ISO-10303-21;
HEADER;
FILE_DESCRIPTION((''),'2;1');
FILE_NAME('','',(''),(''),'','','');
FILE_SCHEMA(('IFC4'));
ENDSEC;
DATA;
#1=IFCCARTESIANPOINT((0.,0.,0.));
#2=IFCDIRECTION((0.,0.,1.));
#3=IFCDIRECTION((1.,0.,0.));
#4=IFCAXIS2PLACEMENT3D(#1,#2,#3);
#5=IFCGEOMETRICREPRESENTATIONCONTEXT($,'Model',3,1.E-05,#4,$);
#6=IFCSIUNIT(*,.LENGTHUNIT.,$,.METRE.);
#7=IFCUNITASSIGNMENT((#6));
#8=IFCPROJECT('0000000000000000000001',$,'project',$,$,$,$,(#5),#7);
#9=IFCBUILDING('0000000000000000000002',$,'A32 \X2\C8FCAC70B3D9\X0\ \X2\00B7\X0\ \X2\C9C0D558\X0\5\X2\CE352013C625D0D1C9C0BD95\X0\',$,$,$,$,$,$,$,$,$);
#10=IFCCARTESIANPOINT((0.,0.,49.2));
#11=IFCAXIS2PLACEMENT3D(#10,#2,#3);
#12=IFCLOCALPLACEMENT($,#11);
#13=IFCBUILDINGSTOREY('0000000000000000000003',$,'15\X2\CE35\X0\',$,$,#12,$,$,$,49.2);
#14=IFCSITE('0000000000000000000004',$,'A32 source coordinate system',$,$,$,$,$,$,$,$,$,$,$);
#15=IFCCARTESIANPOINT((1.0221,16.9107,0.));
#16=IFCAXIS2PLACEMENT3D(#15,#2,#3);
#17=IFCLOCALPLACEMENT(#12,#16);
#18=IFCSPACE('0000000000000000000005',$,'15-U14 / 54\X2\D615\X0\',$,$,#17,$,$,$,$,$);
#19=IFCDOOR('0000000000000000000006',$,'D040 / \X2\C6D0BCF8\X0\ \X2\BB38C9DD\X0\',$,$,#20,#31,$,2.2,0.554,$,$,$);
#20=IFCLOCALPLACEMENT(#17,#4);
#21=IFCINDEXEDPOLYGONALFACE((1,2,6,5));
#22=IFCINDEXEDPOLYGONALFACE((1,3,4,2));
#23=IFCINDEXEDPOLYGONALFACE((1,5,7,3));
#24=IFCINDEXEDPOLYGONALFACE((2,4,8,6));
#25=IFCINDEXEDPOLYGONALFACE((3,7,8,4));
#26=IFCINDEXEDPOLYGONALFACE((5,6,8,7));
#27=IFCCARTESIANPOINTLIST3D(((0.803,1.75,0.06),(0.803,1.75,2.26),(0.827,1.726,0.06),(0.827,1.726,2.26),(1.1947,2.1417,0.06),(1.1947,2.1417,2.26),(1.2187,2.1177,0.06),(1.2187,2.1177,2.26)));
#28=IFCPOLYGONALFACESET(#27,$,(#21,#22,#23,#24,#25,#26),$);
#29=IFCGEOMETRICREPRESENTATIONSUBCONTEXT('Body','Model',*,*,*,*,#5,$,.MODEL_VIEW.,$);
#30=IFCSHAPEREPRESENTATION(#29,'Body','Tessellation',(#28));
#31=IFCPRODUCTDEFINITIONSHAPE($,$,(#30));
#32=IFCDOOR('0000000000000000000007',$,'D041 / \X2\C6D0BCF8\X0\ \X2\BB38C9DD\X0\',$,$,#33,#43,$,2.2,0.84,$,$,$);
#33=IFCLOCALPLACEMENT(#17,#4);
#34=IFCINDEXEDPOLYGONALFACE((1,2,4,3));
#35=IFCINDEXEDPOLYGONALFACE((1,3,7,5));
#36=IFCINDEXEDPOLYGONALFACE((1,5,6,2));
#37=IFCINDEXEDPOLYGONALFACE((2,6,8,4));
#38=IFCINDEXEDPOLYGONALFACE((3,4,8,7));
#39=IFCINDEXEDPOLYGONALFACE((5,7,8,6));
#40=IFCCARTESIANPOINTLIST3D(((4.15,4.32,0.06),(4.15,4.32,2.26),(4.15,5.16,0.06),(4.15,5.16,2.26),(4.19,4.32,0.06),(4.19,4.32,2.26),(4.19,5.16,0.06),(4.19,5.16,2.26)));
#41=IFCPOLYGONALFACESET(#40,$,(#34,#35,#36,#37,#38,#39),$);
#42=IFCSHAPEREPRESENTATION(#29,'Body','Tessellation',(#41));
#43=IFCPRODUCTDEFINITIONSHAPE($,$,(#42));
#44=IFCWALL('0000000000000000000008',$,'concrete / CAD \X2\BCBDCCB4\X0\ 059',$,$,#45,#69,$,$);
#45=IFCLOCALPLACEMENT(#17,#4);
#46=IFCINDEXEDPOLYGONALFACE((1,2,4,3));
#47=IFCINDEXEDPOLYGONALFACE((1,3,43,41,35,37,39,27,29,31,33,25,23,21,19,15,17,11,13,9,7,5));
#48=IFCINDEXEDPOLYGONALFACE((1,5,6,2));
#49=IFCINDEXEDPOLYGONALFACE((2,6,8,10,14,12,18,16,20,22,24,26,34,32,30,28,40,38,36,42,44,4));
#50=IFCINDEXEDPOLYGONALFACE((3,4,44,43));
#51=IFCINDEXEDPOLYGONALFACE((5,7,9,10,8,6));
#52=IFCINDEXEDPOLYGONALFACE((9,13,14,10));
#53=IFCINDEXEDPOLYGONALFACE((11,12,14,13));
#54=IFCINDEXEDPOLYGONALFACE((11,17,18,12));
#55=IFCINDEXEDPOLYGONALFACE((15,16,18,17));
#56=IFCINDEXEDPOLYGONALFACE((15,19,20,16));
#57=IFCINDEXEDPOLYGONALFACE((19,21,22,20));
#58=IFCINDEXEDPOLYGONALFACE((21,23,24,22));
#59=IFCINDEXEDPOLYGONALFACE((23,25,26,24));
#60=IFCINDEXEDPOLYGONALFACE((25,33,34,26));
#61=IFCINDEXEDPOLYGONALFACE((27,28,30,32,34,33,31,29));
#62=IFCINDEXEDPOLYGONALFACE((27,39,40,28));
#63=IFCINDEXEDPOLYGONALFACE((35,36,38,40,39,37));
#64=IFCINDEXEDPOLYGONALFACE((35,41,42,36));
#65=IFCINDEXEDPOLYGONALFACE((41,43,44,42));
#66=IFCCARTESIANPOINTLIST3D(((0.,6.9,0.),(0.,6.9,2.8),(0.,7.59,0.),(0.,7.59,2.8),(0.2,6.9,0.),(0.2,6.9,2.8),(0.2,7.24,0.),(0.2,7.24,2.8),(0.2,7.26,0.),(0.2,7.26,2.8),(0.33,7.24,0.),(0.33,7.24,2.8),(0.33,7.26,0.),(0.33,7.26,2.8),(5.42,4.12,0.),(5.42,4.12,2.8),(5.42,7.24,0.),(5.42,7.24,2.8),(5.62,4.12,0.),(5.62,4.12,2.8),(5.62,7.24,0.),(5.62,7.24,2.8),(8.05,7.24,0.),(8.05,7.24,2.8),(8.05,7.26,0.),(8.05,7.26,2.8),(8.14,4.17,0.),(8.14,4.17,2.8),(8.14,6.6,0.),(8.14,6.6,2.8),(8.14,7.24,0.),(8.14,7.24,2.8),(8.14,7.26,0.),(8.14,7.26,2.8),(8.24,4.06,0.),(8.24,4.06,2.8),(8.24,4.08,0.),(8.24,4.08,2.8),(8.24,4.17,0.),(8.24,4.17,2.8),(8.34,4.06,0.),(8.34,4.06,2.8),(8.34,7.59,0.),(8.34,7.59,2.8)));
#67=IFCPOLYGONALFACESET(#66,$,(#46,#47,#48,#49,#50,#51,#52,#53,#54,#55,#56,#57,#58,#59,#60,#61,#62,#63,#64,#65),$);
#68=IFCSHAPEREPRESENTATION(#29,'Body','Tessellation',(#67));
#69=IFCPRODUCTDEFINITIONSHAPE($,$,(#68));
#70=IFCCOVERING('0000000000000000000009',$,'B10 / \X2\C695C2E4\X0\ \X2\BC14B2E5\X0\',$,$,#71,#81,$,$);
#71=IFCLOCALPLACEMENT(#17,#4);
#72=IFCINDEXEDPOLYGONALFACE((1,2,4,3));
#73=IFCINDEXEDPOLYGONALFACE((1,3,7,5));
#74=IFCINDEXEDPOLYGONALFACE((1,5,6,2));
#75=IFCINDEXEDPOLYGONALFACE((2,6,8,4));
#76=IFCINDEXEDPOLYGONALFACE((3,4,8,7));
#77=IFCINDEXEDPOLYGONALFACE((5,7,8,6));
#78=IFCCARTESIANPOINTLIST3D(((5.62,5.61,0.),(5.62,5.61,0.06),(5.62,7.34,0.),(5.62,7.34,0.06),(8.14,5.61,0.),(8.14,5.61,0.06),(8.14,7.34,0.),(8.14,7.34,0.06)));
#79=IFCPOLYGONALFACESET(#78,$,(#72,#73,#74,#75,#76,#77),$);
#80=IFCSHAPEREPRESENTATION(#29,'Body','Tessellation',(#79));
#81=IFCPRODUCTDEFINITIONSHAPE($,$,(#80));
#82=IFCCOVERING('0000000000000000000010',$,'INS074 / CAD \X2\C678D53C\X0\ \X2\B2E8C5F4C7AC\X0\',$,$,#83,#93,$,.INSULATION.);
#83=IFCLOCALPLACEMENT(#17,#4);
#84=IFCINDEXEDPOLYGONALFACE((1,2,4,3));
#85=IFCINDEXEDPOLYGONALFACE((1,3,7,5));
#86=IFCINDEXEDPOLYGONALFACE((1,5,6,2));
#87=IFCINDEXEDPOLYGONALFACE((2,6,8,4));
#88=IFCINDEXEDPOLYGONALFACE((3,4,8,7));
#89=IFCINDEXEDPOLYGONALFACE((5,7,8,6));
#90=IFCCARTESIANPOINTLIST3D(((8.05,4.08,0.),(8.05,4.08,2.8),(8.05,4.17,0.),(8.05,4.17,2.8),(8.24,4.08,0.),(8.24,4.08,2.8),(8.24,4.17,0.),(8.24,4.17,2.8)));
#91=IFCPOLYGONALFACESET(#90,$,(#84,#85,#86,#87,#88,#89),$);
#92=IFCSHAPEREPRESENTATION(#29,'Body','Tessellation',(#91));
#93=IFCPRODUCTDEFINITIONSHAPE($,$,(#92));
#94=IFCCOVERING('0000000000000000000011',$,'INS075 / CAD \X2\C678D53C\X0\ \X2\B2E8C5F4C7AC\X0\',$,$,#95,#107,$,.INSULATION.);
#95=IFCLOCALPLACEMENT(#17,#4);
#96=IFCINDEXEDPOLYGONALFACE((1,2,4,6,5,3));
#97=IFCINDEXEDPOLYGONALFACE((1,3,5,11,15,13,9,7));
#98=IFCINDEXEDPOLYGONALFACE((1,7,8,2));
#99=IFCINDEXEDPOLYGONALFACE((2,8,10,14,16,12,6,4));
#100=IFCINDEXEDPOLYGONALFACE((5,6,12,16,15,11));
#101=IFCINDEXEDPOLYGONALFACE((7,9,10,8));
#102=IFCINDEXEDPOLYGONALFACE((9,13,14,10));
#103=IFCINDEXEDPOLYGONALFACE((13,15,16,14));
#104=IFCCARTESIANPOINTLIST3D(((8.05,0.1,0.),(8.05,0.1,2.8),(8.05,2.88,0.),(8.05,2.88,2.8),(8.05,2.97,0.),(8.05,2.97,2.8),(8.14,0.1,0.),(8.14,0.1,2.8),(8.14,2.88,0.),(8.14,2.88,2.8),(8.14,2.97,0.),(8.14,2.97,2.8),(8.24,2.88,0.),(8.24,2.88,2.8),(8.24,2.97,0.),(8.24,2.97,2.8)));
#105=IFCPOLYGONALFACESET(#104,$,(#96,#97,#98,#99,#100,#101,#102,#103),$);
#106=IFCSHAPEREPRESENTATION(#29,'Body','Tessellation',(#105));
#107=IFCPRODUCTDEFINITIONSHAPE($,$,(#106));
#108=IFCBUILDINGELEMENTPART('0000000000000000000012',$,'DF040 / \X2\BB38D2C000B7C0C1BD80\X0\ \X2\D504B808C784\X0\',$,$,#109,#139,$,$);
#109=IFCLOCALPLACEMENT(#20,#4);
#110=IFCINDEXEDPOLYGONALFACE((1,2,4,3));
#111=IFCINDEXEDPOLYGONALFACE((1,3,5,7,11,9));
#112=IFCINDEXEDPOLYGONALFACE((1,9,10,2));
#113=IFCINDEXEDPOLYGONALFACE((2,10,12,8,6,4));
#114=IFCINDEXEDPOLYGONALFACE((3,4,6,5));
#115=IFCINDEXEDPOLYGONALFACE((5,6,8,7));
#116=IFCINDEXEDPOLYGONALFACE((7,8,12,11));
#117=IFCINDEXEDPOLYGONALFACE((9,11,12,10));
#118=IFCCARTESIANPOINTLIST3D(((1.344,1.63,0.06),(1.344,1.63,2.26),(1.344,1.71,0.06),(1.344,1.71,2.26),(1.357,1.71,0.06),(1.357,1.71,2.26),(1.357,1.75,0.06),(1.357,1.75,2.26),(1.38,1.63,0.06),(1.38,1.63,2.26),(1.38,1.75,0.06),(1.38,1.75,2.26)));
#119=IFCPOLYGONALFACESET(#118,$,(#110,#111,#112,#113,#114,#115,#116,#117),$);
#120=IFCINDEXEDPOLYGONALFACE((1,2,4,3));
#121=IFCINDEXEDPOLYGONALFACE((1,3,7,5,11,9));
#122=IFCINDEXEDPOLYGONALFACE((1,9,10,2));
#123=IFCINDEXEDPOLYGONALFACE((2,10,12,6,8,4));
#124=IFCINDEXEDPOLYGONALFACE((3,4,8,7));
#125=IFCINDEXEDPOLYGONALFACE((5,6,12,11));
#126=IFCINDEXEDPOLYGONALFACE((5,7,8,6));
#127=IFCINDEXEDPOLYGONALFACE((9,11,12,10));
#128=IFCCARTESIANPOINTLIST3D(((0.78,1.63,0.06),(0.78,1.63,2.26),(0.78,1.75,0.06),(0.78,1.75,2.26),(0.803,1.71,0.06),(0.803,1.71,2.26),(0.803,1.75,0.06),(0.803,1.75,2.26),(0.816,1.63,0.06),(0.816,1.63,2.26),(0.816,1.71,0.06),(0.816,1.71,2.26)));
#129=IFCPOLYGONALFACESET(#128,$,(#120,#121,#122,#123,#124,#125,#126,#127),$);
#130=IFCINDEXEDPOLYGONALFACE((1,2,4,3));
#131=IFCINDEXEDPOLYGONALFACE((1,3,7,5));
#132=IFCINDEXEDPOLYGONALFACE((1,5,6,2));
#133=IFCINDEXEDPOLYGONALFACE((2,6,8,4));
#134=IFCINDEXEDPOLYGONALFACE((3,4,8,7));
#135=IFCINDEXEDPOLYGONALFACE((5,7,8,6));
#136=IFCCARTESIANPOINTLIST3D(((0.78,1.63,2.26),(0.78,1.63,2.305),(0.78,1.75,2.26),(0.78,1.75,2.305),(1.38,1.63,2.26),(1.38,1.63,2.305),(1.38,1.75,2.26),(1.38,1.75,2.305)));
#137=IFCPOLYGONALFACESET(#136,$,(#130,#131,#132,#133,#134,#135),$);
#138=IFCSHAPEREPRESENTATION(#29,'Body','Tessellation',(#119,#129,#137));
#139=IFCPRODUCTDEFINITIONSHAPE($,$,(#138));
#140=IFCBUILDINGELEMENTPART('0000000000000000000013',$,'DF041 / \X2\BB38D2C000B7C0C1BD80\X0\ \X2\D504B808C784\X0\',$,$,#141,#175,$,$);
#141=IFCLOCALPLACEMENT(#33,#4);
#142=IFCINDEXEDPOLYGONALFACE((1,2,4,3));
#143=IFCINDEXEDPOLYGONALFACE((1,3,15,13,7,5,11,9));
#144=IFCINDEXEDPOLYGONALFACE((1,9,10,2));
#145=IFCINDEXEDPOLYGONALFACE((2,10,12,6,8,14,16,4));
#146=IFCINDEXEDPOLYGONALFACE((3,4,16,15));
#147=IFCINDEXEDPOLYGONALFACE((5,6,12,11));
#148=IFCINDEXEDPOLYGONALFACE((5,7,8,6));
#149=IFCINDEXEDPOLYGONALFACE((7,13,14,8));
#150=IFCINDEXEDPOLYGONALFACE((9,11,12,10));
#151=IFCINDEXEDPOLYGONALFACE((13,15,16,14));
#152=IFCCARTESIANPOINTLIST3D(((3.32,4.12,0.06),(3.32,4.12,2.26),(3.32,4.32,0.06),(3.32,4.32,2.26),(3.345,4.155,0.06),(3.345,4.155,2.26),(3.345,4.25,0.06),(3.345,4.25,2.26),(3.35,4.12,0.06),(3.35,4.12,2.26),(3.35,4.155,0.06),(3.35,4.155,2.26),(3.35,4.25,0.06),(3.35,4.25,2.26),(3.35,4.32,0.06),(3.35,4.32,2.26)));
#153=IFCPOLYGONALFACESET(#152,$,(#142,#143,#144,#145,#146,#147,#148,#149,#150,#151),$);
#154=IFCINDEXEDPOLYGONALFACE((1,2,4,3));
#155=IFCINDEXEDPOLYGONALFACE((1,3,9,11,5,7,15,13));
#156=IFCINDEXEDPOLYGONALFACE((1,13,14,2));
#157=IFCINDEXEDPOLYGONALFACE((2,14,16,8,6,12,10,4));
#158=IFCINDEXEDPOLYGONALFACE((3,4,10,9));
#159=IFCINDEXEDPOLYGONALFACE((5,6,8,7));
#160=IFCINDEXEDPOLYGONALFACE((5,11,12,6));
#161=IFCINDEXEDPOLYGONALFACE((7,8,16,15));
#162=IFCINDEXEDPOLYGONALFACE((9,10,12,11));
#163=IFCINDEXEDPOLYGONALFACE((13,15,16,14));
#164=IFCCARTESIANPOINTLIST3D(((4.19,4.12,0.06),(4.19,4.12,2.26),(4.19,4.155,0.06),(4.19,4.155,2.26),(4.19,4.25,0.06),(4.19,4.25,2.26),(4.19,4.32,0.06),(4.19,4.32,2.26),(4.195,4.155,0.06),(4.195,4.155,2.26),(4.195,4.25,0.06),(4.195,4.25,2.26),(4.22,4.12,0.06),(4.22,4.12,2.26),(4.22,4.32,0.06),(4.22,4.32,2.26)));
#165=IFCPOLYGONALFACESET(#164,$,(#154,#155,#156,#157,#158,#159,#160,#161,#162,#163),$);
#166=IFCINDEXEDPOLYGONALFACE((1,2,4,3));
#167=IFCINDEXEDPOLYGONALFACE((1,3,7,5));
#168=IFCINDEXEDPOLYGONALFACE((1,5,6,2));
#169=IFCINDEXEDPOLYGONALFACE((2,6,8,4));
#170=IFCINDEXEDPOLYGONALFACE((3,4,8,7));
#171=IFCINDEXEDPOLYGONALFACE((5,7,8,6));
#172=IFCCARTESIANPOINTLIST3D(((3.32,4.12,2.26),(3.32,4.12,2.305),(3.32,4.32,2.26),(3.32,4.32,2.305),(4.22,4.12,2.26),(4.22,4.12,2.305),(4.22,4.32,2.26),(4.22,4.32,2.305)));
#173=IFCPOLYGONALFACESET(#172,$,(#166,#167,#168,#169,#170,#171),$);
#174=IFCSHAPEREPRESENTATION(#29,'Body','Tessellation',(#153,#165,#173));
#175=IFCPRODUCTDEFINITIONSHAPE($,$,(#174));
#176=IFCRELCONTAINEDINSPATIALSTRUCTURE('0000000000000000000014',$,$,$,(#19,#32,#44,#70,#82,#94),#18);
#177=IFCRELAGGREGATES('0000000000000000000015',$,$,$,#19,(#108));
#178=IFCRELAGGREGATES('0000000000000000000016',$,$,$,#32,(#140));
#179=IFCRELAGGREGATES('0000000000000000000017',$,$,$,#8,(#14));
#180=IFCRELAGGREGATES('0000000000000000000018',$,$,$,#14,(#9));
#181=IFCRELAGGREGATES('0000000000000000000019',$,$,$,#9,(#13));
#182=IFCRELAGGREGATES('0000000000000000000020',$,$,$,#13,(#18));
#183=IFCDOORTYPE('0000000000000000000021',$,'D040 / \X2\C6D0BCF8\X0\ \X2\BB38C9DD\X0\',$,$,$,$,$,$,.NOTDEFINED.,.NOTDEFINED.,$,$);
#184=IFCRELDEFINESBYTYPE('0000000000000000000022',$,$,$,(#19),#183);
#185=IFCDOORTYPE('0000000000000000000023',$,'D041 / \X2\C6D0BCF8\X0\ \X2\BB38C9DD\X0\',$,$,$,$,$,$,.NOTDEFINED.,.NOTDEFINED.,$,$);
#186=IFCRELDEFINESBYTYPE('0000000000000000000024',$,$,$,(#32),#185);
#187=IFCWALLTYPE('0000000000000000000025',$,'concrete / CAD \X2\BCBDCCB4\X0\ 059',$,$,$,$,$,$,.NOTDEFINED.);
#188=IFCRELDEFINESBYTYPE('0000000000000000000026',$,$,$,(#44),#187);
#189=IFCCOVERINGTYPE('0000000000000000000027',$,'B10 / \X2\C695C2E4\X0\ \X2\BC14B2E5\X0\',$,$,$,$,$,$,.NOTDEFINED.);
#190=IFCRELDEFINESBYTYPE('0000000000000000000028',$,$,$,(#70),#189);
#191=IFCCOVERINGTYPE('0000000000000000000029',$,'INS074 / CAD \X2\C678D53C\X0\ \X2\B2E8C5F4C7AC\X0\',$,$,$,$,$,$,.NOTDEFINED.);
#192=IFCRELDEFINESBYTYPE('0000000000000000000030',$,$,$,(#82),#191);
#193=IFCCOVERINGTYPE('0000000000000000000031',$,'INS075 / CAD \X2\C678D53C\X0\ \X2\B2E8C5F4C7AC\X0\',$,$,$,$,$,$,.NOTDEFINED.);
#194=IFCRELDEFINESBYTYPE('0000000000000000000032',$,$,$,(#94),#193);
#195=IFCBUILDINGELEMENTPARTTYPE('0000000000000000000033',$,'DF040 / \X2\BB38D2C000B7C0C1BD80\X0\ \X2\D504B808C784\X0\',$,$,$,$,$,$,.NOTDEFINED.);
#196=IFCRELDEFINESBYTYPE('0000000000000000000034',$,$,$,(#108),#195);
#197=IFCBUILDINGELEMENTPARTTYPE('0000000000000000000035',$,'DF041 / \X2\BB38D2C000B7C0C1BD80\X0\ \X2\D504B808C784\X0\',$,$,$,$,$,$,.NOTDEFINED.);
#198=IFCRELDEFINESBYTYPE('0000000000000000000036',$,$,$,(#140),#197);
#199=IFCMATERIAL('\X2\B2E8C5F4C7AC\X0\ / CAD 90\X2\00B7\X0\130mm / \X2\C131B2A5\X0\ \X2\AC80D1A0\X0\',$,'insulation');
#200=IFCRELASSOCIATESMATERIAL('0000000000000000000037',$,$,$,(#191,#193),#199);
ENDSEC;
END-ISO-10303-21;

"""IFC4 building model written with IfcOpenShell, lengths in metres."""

from ifc_helpers import new_model, si_unit, frame, origin, origin_with_axes, place, context, subcontext, project, spatial, polyline, outline, extrude, source, transform, mapped, material, type_object, type_shapes, element, aggregate, save


model = new_model("IFC4")

# Units and contexts
model_context = context("Model", 3, precision=1e-05, world=origin_with_axes())
body_context = subcontext(model_context, "Body", "Model", "MODEL_VIEW")
ifc_project = project(units=[si_unit("LENGTHUNIT", "METRE")], contexts=[model_context])

# Site, building, storey, space
storey_placement = place(None, frame((0.0, 0.0, 49.2), z_axis=(0.0, 0.0, 1.0), x_axis=(1.0, 0.0, 0.0)))
space_1_placement = place(storey_placement, frame((1.0221, 16.9107, 0.0), z_axis=(0.0, 0.0, 1.0), x_axis=(1.0, 0.0, 0.0)))
site = spatial("IfcSite", under=ifc_project, Name="A32 source coordinate system")
building = spatial("IfcBuilding", under=site, Name="A32 주거동 · 지하5층–옥탑지붕")
storey = spatial("IfcBuildingStorey", under=building, at=storey_placement, Name="15층", Elevation=49.2)
space_1 = spatial("IfcSpace", under=storey, at=space_1_placement, Name="15-U14 / 54형")

# Doors
door_type_1 = type_object("IfcDoorType", Name="D040 / 원본 문짝", OperationType="NOTDEFINED", PredefinedType="NOTDEFINED")
shared_shape_1 = source(origin(), body_context, "Body", "SweptSolid", [
    extrude(outline(polyline([(0.803, 1.75), (1.1947, 2.1417), (1.2187, 2.1177), (0.827, 1.726), (0.803, 1.75)])), frame((0.0, 0.0, 0.06)), (0.0, 0.0, 1.0), 2.2),
])
type_shapes(door_type_1, [shared_shape_1])
door_1_placement = place(space_1_placement, origin_with_axes())
door_1 = element("IfcDoor", 1, at=door_1_placement, inside=space_1, type_object=door_type_1, Name="D040 / 원본 문짝", OverallHeight=2.2, OverallWidth=0.554, context=body_context, shape_type="MappedRepresentation", body=[
    mapped(shared_shape_1, transform((0.0, 0.0, 0.0), scale=1.0)),
])
door_type_2 = type_object("IfcDoorType", Name="D041 / 원본 문짝", OperationType="NOTDEFINED", PredefinedType="NOTDEFINED")
shared_shape_2 = source(origin(), body_context, "Body", "SweptSolid", [
    extrude(outline(polyline([(4.15, 5.16), (4.19, 5.16), (4.19, 4.32), (4.15, 4.32), (4.15, 5.16)])), frame((0.0, 0.0, 0.06)), (0.0, 0.0, 1.0), 2.2),
])
type_shapes(door_type_2, [shared_shape_2])
door_2_placement = place(space_1_placement, origin_with_axes())
door_2 = element("IfcDoor", 2, at=door_2_placement, inside=space_1, type_object=door_type_2, Name="D041 / 원본 문짝", OverallHeight=2.2, OverallWidth=0.84, context=body_context, shape_type="MappedRepresentation", body=[
    mapped(shared_shape_2, transform((0.0, 0.0, 0.0), scale=1.0)),
])

# Wall
wall_type_1 = type_object("IfcWallType", Name="concrete / CAD 벽체 059", PredefinedType="NOTDEFINED")
shared_shape_3 = source(origin(), body_context, "Body", "SweptSolid", [
    extrude(outline(polyline([(8.05, 7.26), (8.05, 7.24), (5.62, 7.24), (5.62, 4.12), (5.42, 4.12), (5.42, 7.24), (0.33, 7.24), (0.33, 7.26), (0.2, 7.26), (0.2, 7.24), (0.2, 6.9), (0.0, 6.9), (0.0, 7.59), (8.34, 7.59), (8.34, 4.06), (8.24, 4.06), (8.24, 4.08), (8.24, 4.17), (8.14, 4.17), (8.14, 6.6), (8.14, 7.24), (8.14, 7.26), (8.05, 7.26)])), origin(), (0.0, 0.0, 1.0), 2.8),
])
type_shapes(wall_type_1, [shared_shape_3])
wall_1_placement = place(space_1_placement, origin_with_axes())
element("IfcWall", 3, at=wall_1_placement, inside=space_1, type_object=wall_type_1, Name="concrete / CAD 벽체 059", context=body_context, shape_type="MappedRepresentation", body=[
    mapped(shared_shape_3, transform((0.0, 0.0, 0.0), scale=1.0)),
])

# Coverings
covering_type_1 = type_object("IfcCoveringType", Name="B10 / 욕실 바닥", PredefinedType="NOTDEFINED")
shared_shape_4 = source(origin(), body_context, "Body", "SweptSolid", [
    extrude(outline(polyline([(8.14, 5.61), (5.62, 5.61), (5.62, 7.34), (8.14, 7.34), (8.14, 5.61)])), origin(), (0.0, 0.0, 1.0), 0.06),
])
type_shapes(covering_type_1, [shared_shape_4])
covering_1_placement = place(space_1_placement, origin_with_axes())
element("IfcCovering", 4, at=covering_1_placement, inside=space_1, type_object=covering_type_1, Name="B10 / 욕실 바닥", context=body_context, shape_type="MappedRepresentation", body=[
    mapped(shared_shape_4, transform((0.0, 0.0, 0.0), scale=1.0)),
])
ifc_material = material(Name="단열재 / CAD 90·130mm / 성능 검토", Category="insulation")
covering_type_2 = type_object("IfcCoveringType", Name="INS074 / CAD 외피 단열재", PredefinedType="NOTDEFINED", material=ifc_material)
shared_shape_5 = source(origin(), body_context, "Body", "SweptSolid", [
    extrude(outline(polyline([(8.05, 4.08), (8.05, 4.17), (8.24, 4.17), (8.24, 4.08), (8.05, 4.08)])), origin(), (0.0, 0.0, 1.0), 2.8),
])
type_shapes(covering_type_2, [shared_shape_5])
covering_2_placement = place(space_1_placement, origin_with_axes())
element("IfcCovering", 5, at=covering_2_placement, inside=space_1, type_object=covering_type_2, Name="INS074 / CAD 외피 단열재", PredefinedType="INSULATION", context=body_context, shape_type="MappedRepresentation", body=[
    mapped(shared_shape_5, transform((0.0, 0.0, 0.0), scale=1.0)),
])
covering_type_3 = type_object("IfcCoveringType", Name="INS075 / CAD 외피 단열재", PredefinedType="NOTDEFINED", material=ifc_material)
shared_shape_6 = source(origin(), body_context, "Body", "SweptSolid", [
    extrude(outline(polyline([(8.24, 2.88), (8.14, 2.88), (8.14, 0.1), (8.05, 0.1), (8.05, 2.88), (8.05, 2.97), (8.14, 2.97), (8.24, 2.97), (8.24, 2.88)])), origin(), (0.0, 0.0, 1.0), 2.8),
])
type_shapes(covering_type_3, [shared_shape_6])
covering_3_placement = place(space_1_placement, origin_with_axes())
element("IfcCovering", 6, at=covering_3_placement, inside=space_1, type_object=covering_type_3, Name="INS075 / CAD 외피 단열재", PredefinedType="INSULATION", context=body_context, shape_type="MappedRepresentation", body=[
    mapped(shared_shape_6, transform((0.0, 0.0, 0.0), scale=1.0)),
])

# Building element parts
building_element_part_type_1 = type_object("IfcBuildingElementPartType", Name="DF040 / 문틀·상부 프레임", PredefinedType="NOTDEFINED")
shared_shape_7 = source(origin(), body_context, "Body", "SweptSolid", [
    extrude(outline(polyline([(1.344, 1.63), (1.344, 1.71), (1.357, 1.71), (1.357, 1.75), (1.38, 1.75), (1.38, 1.63), (1.344, 1.63)])), frame((0.0, 0.0, 0.06)), (0.0, 0.0, 1.0), 2.2),
    extrude(outline(polyline([(0.78, 1.75), (0.803, 1.75), (0.803, 1.71), (0.816, 1.71), (0.816, 1.63), (0.78, 1.63), (0.78, 1.75)])), frame((0.0, 0.0, 0.06)), (0.0, 0.0, 1.0), 2.2),
    extrude(outline(polyline([(0.78, 1.63), (0.78, 1.75), (1.38, 1.75), (1.38, 1.63), (0.78, 1.63)])), frame((0.0, 0.0, 2.26)), (0.0, 0.0, 1.0), 0.045),
])
type_shapes(building_element_part_type_1, [shared_shape_7])
building_element_part_1_placement = place(door_1_placement, origin_with_axes())
building_element_part_1 = element("IfcBuildingElementPart", 7, at=building_element_part_1_placement, type_object=building_element_part_type_1, Name="DF040 / 문틀·상부 프레임", context=body_context, shape_type="MappedRepresentation", body=[
    mapped(shared_shape_7, transform((0.0, 0.0, 0.0), scale=1.0)),
])
aggregate(door_1, [building_element_part_1])
building_element_part_type_2 = type_object("IfcBuildingElementPartType", Name="DF041 / 문틀·상부 프레임", PredefinedType="NOTDEFINED")
shared_shape_8 = source(origin(), body_context, "Body", "SweptSolid", [
    extrude(outline(polyline([(3.35, 4.32), (3.35, 4.25), (3.345, 4.25), (3.345, 4.155), (3.35, 4.155), (3.35, 4.12), (3.32, 4.12), (3.32, 4.32), (3.35, 4.32)])), frame((0.0, 0.0, 0.06)), (0.0, 0.0, 1.0), 2.2),
    extrude(outline(polyline([(4.22, 4.12), (4.19, 4.12), (4.19, 4.155), (4.195, 4.155), (4.195, 4.25), (4.19, 4.25), (4.19, 4.32), (4.22, 4.32), (4.22, 4.12)])), frame((0.0, 0.0, 0.06)), (0.0, 0.0, 1.0), 2.2),
    extrude(outline(polyline([(3.32, 4.12), (3.32, 4.32), (4.22, 4.32), (4.22, 4.12), (3.32, 4.12)])), frame((0.0, 0.0, 2.26)), (0.0, 0.0, 1.0), 0.045),
])
type_shapes(building_element_part_type_2, [shared_shape_8])
building_element_part_2_placement = place(door_2_placement, origin_with_axes())
building_element_part_2 = element("IfcBuildingElementPart", 8, at=building_element_part_2_placement, type_object=building_element_part_type_2, Name="DF041 / 문틀·상부 프레임", context=body_context, shape_type="MappedRepresentation", body=[
    mapped(shared_shape_8, transform((0.0, 0.0, 0.0), scale=1.0)),
])
aggregate(door_2, [building_element_part_2])

save(model, "model.ifc")
